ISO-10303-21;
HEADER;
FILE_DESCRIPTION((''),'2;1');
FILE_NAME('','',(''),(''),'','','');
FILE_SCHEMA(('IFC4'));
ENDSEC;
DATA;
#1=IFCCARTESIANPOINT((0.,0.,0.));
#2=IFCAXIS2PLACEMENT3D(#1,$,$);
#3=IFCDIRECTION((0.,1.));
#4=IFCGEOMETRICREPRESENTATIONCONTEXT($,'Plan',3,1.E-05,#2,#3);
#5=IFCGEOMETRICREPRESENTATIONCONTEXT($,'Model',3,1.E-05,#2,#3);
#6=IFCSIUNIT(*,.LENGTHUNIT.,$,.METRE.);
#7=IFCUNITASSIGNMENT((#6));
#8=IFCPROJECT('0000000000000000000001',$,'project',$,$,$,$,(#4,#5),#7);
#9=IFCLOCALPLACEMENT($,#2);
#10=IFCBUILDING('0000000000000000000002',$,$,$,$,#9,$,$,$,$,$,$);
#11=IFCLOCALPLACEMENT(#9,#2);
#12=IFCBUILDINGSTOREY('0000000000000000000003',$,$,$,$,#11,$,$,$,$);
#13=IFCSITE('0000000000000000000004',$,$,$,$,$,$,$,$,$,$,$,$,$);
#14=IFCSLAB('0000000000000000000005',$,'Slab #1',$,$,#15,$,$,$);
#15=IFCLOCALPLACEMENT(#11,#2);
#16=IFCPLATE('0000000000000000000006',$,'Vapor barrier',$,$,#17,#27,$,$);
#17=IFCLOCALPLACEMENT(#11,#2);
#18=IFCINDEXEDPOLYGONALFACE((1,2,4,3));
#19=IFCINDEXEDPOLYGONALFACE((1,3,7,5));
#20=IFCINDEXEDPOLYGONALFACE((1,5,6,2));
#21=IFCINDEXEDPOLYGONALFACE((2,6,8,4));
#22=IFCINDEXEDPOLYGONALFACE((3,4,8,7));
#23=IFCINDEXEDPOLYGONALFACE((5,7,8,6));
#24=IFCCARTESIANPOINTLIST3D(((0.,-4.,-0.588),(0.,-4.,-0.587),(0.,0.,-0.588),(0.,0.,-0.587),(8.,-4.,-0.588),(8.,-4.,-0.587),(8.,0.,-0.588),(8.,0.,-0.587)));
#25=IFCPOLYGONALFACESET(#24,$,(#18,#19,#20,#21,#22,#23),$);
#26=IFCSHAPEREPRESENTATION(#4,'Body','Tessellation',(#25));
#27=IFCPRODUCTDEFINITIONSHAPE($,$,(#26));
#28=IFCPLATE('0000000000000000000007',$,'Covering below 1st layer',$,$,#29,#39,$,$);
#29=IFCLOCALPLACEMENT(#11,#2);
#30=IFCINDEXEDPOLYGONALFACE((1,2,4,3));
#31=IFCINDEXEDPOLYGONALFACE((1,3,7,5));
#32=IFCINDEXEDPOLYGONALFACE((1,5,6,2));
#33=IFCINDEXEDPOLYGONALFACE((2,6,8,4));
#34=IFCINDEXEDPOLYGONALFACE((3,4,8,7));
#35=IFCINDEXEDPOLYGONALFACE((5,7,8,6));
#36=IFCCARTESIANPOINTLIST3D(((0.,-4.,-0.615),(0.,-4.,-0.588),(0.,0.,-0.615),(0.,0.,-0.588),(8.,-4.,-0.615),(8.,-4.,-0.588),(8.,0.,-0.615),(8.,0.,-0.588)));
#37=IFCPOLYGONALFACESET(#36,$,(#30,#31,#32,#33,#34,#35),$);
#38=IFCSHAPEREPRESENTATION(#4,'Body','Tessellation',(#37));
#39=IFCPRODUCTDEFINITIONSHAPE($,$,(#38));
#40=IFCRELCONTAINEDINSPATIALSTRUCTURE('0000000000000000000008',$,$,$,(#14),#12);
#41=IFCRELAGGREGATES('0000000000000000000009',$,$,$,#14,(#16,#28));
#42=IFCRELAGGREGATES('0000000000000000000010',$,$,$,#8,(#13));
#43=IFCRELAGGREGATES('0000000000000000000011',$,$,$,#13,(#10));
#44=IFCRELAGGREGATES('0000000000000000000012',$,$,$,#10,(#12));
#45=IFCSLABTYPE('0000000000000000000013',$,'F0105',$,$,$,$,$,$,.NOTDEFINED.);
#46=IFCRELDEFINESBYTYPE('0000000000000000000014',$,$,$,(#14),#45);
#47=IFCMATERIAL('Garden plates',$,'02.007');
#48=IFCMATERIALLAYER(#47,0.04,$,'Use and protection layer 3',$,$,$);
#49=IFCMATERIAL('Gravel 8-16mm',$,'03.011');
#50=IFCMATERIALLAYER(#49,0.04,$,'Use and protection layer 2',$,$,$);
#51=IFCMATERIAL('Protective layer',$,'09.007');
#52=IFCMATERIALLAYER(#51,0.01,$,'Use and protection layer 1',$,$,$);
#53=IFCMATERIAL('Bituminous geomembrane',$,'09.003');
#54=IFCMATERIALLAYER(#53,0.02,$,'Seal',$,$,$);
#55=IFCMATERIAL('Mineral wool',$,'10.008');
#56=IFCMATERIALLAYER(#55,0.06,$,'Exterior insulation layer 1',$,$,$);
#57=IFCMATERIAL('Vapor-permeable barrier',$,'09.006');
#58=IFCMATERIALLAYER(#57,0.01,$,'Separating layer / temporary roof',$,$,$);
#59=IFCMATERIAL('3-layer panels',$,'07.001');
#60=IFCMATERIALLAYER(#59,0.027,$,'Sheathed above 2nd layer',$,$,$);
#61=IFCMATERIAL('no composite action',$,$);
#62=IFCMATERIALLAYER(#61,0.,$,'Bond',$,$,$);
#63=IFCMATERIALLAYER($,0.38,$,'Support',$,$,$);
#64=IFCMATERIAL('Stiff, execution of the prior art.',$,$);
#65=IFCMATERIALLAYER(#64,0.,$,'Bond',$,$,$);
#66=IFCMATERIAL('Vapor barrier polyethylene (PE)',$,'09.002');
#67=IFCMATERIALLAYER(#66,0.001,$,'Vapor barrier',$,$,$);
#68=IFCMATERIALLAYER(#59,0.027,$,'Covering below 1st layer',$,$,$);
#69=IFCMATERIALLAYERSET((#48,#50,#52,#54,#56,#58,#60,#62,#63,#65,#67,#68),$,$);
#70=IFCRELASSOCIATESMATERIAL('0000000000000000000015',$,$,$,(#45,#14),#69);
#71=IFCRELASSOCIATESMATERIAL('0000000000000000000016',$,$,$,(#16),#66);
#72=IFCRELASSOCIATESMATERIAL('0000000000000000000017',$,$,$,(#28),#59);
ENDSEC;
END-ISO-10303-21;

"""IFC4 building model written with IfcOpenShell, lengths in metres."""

from ifc_helpers import new_model, si_unit, direction, frame, frame_2d, origin, place, context, project, spatial, rectangle, extrude, material, layer, layer_set, type_object, element, aggregate, save


model = new_model("IFC4")

# Units and contexts
plan_context = context("Plan", 3, precision=1e-05, world=origin(), true_north=direction((0.0, 1.0)))
model_context = context("Model", 3, precision=1e-05, world=origin(), true_north=direction((0.0, 1.0)))
ifc_project = project(units=[si_unit("LENGTHUNIT", "METRE")], contexts=[plan_context, model_context])

# Site, building, storey
site = spatial("IfcSite", under=ifc_project)
building_placement = place(None, origin())
building = spatial("IfcBuilding", under=site, at=building_placement)
storey_placement = place(building_placement, origin())
storey = spatial("IfcBuildingStorey", under=building, at=storey_placement)

# Slab, plates
ifc_material_1 = material(Name="Garden plates", Category="02.007")
ifc_layer_1 = layer(ifc_material_1, 0.04, Name="Use and protection layer 3")
ifc_material_2 = material(Name="Gravel 8-16mm", Category="03.011")
ifc_layer_2 = layer(ifc_material_2, 0.04, Name="Use and protection layer 2")
ifc_material_3 = material(Name="Protective layer", Category="09.007")
ifc_layer_3 = layer(ifc_material_3, 0.01, Name="Use and protection layer 1")
ifc_material_4 = material(Name="Bituminous geomembrane", Category="09.003")
ifc_layer_4 = layer(ifc_material_4, 0.02, Name="Seal")
ifc_material_5 = material(Name="Mineral wool", Category="10.008")
ifc_layer_5 = layer(ifc_material_5, 0.06, Name="Exterior insulation layer 1")
ifc_material_6 = material(Name="Vapor-permeable barrier", Category="09.006")
ifc_layer_6 = layer(ifc_material_6, 0.01, Name="Separating layer / temporary roof")
ifc_material_7 = material(Name="3-layer panels", Category="07.001")
ifc_layer_7 = layer(ifc_material_7, 0.027, Name="Sheathed above 2nd layer")
ifc_material_8 = material(Name="no composite action")
ifc_layer_8 = layer(ifc_material_8, 0.0, Name="Bond")
ifc_layer_9 = layer(None, 0.38, Name="Support")
ifc_material_9 = material(Name="Stiff, execution of the prior art.")
ifc_layer_10 = layer(ifc_material_9, 0.0, Name="Bond")
ifc_material_10 = material(Name="Vapor barrier polyethylene (PE)", Category="09.002")
ifc_layer_11 = layer(ifc_material_10, 0.001, Name="Vapor barrier")
ifc_layer_12 = layer(ifc_material_7, 0.027, Name="Covering below 1st layer")
ifc_layer_set = layer_set([ifc_layer_1, ifc_layer_2, ifc_layer_3, ifc_layer_4, ifc_layer_5, ifc_layer_6, ifc_layer_7, ifc_layer_8, ifc_layer_9, ifc_layer_10, ifc_layer_11, ifc_layer_12])
slab_type = type_object("IfcSlabType", Name="F0105", PredefinedType="NOTDEFINED", material=ifc_layer_set)
slab_placement = place(None, frame((0.0, 0.0, 0.0), z_axis=(0.0, 0.0, -1.0), x_axis=(1.0, 0.0, 0.0)))
slab = element("IfcSlab", 1, at=slab_placement, inside=storey, type_object=slab_type, material=ifc_layer_set, Name="Slab #1")
plate_1_placement = place(slab_placement, origin())
plate_1 = element("IfcPlate", 2, at=plate_1_placement, material=ifc_material_10, Name="Vapor barrier", context=plan_context, shape_type="SweptSolid", body=[
    extrude(rectangle(XDim=8.0, YDim=4.0, at=frame_2d((4.0, 2.0), x_axis=(1.0, 0.0))), frame((0.0, 0.0, 0.587), z_axis=(0.0, 0.0, 1.0), x_axis=(1.0, 0.0, 0.0)), (0.0, 0.0, 1.0), 0.001),
])
plate_2_placement = place(slab_placement, origin())
plate_2 = element("IfcPlate", 3, at=plate_2_placement, material=ifc_material_7, Name="Covering below 1st layer", context=plan_context, shape_type="SweptSolid", body=[
    extrude(rectangle(XDim=8.0, YDim=4.0, at=frame_2d((4.0, 2.0), x_axis=(1.0, 0.0))), frame((0.0, 0.0, 0.588), z_axis=(0.0, 0.0, 1.0), x_axis=(1.0, 0.0, 0.0)), (0.0, 0.0, 1.0), 0.027),
])
aggregate(slab, [plate_1, plate_2])

save(model, "model.ifc")
